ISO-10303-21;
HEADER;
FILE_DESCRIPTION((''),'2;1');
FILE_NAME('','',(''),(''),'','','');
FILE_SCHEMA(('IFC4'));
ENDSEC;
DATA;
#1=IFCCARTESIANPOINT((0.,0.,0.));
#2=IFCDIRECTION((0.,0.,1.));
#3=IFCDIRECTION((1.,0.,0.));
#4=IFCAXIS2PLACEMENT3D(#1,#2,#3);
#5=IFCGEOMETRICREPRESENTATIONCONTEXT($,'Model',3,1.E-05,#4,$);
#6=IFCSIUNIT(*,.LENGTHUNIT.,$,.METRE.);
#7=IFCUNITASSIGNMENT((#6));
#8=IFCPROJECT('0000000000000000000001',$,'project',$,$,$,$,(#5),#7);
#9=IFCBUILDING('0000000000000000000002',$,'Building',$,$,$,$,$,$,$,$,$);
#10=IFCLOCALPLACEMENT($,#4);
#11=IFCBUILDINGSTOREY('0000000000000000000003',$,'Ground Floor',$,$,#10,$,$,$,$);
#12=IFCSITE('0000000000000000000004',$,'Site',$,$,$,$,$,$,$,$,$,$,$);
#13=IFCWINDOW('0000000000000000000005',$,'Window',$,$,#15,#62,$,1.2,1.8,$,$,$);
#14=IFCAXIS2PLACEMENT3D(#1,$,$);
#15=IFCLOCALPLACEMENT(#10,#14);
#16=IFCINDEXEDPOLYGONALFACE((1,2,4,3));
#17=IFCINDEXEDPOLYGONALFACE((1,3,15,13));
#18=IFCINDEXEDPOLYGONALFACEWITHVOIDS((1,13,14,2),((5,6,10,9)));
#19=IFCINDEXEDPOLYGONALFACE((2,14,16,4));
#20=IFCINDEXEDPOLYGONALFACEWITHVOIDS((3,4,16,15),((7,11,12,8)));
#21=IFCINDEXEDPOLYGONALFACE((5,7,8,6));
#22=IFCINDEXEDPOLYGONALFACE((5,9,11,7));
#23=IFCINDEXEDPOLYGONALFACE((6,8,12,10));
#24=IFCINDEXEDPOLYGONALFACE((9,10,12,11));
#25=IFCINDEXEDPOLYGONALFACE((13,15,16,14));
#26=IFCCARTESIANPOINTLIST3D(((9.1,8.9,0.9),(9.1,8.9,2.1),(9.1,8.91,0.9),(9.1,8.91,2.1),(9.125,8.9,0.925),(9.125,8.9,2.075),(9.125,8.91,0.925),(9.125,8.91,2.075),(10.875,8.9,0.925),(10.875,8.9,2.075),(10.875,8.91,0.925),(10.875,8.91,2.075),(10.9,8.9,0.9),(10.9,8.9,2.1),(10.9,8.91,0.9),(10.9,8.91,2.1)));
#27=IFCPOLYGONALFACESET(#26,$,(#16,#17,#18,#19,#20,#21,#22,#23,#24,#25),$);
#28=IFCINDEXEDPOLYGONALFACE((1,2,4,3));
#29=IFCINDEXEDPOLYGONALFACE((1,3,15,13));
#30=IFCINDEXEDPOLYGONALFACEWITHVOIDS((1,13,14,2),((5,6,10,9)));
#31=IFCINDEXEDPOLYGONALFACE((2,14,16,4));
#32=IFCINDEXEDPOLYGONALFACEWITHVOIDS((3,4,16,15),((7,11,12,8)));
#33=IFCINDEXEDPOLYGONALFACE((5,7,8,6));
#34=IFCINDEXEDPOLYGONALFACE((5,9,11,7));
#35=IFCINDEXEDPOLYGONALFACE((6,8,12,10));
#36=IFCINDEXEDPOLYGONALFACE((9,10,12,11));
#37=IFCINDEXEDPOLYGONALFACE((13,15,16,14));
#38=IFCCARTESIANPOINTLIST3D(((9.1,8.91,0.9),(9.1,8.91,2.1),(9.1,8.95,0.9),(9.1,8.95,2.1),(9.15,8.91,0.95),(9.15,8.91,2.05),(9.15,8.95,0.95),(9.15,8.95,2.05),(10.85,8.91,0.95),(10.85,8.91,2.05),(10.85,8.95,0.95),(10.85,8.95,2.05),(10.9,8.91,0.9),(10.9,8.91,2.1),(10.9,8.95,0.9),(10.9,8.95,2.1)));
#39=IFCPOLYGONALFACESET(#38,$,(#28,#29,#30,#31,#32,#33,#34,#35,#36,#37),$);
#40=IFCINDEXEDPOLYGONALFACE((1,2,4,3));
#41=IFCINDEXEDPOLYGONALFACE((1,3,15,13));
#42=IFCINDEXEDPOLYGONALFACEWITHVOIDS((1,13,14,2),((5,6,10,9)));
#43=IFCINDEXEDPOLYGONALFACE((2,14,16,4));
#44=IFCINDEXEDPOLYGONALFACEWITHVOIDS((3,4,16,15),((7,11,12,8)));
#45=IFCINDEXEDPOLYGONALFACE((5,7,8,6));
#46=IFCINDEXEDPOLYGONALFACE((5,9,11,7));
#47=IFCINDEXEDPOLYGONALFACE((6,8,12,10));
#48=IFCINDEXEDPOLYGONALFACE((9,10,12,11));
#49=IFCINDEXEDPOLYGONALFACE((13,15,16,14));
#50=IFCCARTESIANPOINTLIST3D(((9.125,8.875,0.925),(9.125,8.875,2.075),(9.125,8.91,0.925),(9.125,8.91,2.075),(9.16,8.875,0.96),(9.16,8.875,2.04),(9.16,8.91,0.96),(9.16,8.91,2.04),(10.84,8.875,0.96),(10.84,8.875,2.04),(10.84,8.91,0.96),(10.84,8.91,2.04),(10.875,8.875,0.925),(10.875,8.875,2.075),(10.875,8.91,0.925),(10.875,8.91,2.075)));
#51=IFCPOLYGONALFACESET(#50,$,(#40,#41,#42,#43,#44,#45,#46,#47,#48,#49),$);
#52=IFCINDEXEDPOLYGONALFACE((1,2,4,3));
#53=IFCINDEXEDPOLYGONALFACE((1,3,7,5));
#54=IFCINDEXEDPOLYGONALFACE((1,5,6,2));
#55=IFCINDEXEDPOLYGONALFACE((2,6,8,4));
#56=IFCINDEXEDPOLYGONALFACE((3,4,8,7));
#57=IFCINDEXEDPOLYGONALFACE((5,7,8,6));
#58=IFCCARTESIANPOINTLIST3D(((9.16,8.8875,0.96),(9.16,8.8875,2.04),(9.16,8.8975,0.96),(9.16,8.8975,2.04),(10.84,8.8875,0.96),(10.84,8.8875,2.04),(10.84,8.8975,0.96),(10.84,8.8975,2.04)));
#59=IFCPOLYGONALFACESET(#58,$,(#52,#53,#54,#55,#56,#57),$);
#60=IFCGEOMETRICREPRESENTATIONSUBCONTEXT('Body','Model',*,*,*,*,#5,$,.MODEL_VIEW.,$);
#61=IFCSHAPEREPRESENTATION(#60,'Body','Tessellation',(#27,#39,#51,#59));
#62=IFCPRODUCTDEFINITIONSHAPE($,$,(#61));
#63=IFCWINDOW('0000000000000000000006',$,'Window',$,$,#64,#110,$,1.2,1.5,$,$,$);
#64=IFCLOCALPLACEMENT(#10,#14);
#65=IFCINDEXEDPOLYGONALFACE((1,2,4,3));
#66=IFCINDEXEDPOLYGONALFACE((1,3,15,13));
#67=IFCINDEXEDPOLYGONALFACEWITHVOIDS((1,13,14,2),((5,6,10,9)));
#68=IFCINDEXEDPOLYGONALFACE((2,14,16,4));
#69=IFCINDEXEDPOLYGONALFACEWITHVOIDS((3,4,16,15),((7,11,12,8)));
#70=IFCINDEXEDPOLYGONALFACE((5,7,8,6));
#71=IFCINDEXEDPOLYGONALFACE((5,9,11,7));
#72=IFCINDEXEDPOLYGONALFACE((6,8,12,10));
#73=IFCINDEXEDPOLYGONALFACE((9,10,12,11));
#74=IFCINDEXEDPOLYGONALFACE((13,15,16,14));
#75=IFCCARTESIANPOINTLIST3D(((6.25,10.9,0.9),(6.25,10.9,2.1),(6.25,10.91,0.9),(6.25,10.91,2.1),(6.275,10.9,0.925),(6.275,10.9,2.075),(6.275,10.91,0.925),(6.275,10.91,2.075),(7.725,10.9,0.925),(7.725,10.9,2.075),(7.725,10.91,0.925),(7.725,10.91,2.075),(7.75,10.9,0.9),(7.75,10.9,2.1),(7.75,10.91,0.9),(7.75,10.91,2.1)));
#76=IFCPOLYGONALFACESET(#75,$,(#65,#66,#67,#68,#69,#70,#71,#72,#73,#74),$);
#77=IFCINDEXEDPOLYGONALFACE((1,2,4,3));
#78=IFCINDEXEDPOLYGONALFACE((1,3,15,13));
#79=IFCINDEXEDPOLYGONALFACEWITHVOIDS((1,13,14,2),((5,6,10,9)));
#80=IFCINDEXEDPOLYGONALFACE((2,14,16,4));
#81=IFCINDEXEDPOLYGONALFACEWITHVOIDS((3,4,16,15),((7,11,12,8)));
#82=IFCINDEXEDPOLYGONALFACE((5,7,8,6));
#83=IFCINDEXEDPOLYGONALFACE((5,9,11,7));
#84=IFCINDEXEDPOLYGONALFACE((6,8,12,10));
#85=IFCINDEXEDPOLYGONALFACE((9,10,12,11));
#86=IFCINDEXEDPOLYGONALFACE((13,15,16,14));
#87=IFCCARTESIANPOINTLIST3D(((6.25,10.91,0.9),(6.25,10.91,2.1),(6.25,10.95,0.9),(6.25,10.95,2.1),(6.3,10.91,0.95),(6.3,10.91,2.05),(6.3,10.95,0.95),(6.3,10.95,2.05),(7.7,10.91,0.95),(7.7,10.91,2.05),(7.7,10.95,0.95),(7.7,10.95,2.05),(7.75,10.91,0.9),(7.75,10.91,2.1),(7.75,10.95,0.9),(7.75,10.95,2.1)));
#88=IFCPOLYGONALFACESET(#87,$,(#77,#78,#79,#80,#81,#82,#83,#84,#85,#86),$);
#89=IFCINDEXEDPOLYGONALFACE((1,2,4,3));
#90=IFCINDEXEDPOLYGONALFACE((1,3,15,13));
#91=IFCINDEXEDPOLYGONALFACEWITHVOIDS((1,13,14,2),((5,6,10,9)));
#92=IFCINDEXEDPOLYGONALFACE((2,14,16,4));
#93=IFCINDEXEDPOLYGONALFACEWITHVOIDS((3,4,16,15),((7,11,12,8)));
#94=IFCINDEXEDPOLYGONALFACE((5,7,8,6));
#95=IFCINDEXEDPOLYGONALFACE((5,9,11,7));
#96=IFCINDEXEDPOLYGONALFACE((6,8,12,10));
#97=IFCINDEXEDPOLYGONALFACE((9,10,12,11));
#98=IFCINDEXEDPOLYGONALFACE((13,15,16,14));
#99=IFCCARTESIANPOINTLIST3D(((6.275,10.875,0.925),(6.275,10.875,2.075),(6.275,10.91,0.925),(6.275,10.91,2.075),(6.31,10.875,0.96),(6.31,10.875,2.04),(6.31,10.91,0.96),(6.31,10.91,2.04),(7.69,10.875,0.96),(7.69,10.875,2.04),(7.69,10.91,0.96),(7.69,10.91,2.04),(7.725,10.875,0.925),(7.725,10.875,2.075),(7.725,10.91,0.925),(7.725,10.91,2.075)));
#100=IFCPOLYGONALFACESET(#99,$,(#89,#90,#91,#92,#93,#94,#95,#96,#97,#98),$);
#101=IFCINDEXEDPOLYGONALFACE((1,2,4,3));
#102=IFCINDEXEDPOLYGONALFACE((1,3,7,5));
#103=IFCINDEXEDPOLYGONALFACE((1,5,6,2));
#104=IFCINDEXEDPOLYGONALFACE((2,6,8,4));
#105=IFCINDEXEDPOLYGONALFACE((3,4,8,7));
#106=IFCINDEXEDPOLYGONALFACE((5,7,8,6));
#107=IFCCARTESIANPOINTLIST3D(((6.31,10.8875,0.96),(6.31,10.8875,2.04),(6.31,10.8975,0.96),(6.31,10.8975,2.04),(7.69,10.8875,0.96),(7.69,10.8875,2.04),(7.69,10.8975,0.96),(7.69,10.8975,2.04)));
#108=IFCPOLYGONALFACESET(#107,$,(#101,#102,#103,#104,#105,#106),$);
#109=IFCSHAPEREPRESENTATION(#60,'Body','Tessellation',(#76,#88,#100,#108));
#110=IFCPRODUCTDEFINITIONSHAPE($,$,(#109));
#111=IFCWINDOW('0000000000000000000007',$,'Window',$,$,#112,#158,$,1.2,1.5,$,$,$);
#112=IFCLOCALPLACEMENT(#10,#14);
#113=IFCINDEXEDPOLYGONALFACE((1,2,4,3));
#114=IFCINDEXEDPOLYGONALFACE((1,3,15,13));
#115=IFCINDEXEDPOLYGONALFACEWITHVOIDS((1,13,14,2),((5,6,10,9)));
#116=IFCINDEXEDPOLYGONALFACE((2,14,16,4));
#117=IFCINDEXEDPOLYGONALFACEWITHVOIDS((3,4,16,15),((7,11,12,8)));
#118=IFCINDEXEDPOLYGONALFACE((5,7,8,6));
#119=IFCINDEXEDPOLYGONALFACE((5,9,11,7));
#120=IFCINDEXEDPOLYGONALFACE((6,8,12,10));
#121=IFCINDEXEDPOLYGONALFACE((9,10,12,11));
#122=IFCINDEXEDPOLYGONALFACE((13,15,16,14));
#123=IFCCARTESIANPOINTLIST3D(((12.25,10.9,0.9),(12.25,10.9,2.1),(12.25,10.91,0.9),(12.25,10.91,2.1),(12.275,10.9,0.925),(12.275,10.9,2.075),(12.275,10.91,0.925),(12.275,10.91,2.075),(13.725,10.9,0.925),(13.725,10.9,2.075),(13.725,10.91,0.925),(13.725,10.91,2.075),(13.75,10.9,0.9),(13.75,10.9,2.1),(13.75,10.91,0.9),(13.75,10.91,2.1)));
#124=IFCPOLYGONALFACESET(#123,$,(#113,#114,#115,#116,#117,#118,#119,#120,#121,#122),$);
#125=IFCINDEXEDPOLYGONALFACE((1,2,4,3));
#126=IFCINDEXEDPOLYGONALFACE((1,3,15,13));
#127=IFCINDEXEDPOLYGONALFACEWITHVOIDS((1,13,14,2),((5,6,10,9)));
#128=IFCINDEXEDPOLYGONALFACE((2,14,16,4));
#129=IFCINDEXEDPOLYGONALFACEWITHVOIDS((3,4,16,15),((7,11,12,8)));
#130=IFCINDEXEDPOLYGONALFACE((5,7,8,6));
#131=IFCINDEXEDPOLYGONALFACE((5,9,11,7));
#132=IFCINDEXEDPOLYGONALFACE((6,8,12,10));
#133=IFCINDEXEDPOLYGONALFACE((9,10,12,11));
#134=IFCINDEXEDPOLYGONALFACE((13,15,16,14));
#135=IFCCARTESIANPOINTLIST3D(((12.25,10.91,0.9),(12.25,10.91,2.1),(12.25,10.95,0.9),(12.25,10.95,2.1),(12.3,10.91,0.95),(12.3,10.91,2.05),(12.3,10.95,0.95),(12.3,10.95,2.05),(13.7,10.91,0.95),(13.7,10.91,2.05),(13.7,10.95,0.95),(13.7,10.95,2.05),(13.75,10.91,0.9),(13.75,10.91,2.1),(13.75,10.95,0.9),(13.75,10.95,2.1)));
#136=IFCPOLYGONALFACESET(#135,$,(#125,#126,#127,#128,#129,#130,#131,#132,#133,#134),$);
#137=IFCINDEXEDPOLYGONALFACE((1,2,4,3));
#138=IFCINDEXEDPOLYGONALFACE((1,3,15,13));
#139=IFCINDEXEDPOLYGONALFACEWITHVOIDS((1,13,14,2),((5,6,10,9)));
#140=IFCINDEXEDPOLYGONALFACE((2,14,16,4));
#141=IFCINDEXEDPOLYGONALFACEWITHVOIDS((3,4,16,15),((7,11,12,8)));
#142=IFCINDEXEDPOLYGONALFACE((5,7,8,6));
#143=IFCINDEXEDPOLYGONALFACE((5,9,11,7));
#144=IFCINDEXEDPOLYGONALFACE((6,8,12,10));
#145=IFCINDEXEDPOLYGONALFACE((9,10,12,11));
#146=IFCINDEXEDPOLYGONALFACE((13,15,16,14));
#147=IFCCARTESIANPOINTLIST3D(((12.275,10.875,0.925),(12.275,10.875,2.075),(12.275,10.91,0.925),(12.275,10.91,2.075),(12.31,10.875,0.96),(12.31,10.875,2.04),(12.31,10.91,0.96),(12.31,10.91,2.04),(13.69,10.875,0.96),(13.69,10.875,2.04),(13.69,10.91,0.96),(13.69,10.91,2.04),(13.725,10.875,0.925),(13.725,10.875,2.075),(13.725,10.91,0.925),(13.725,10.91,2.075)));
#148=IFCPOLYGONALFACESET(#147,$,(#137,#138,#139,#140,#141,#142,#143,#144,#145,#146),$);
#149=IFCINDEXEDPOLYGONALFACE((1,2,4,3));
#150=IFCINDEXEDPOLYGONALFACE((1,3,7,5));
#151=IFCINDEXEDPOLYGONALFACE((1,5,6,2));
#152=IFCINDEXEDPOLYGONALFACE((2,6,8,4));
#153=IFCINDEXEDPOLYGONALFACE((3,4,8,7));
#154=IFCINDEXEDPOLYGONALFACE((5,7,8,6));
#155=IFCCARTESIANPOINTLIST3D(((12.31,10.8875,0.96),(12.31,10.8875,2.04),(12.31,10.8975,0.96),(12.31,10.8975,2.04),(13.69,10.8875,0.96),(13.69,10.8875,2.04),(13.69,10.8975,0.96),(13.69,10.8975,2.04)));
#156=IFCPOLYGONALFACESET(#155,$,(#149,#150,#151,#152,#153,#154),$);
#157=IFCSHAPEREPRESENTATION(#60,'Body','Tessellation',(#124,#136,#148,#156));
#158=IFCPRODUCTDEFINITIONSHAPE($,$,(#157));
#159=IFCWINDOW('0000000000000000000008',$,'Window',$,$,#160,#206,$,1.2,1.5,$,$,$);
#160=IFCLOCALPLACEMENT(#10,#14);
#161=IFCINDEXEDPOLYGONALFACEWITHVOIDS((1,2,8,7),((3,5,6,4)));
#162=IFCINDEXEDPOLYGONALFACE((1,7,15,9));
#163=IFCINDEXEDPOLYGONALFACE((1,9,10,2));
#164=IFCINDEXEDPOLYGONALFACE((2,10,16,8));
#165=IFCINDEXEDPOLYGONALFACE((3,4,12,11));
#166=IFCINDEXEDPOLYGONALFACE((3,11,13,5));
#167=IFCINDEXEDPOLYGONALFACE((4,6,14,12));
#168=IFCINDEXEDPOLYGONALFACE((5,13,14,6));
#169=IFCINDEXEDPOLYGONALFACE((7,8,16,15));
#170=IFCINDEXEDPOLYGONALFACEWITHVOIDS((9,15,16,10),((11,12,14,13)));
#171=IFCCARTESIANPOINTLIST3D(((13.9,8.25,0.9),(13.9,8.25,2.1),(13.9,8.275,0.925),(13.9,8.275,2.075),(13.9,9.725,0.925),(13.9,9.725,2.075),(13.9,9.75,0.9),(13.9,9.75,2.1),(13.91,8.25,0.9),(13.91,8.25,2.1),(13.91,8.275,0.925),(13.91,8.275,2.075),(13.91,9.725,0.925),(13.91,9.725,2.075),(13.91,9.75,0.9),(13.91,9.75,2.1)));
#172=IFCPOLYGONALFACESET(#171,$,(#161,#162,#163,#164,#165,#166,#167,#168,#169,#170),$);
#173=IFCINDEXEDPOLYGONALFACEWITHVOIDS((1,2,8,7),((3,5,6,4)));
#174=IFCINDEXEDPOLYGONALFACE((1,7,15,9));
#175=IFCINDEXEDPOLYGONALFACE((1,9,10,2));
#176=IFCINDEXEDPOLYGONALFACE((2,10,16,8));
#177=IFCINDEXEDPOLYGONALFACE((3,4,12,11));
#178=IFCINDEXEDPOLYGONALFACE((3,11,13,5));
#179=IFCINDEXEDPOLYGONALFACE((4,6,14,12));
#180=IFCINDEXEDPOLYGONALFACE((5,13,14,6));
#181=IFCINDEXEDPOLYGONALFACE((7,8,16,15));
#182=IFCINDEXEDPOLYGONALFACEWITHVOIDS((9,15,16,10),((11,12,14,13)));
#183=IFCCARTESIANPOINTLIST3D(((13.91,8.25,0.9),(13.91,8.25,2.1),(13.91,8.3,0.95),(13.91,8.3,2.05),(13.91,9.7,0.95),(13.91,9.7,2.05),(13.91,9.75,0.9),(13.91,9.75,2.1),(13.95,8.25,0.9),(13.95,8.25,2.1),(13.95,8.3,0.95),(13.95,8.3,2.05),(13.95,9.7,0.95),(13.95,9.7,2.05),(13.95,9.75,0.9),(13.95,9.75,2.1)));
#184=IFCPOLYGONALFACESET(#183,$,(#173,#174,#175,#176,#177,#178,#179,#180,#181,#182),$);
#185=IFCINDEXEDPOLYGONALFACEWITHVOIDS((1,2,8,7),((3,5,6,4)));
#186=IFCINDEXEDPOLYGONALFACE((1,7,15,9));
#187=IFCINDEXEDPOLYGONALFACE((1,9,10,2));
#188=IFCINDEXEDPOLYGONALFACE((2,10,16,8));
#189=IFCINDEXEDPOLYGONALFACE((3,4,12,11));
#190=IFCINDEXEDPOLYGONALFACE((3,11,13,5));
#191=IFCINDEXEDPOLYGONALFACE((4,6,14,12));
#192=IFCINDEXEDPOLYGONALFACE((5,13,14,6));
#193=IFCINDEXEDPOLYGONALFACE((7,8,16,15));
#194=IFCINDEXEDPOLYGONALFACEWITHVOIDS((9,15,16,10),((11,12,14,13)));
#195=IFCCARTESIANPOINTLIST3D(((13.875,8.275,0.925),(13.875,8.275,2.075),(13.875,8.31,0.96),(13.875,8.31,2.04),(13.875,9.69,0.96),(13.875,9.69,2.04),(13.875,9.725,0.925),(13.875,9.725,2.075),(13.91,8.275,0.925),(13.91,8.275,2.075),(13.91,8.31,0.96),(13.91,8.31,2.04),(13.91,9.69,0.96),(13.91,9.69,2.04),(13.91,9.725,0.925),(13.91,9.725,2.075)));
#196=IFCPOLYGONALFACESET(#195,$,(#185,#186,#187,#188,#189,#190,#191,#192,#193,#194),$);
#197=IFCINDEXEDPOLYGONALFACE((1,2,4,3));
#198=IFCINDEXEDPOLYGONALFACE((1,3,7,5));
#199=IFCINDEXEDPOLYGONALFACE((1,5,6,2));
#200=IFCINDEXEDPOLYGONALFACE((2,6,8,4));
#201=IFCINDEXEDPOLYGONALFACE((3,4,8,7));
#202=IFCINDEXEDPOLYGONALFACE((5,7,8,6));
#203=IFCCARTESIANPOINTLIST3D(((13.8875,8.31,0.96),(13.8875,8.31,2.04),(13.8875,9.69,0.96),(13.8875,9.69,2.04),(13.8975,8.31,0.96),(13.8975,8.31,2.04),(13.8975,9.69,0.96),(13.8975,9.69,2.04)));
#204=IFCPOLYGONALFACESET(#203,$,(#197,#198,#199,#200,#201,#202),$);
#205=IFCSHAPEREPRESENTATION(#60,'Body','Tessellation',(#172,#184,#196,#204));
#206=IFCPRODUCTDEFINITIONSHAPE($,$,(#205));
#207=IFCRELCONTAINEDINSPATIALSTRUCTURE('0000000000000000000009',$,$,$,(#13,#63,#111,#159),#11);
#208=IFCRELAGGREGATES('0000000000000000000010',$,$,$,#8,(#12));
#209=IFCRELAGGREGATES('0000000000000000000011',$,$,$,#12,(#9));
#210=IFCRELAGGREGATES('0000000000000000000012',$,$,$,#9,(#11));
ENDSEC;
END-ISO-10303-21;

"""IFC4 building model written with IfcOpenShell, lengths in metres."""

from ifc_helpers import new_model, si_unit, frame, origin_with_axes, place, context, subcontext, project, spatial, line, indexed_curve, outline, extrude, element, save


model = new_model("IFC4")

# Units and contexts
model_context = context("Model", 3, precision=1e-05, world=origin_with_axes())
body_context = subcontext(model_context, "Body", "Model", "MODEL_VIEW")
ifc_project = project(units=[si_unit("LENGTHUNIT", "METRE")], contexts=[model_context])

# Site, building, storey
site = spatial("IfcSite", under=ifc_project, Name="Site")
building = spatial("IfcBuilding", under=site, Name="Building")
storey_placement = place(None, origin_with_axes())
storey = spatial("IfcBuildingStorey", under=building, at=storey_placement, Name="Ground Floor")

# Windows
window_1_placement = place(storey_placement, frame((10.9, 9.0, 0.9), z_axis=(0.0, 0.0, 1.0), x_axis=(-1.0, 0.0, 0.0)))
element("IfcWindow", 1, at=window_1_placement, inside=storey, Name="Window", OverallHeight=1.2, OverallWidth=1.8, context=body_context, shape_type="SweptSolid", body=[
    extrude(outline(indexed_curve([(0.0, 0.0), (1.8, 0.0), (1.8, 1.2), (0.0, 1.2)], segments=[line(1, 2, 3, 4, 1)]), holes=[indexed_curve([(0.025, 0.025), (1.775, 0.025), (1.775, 1.175), (0.025, 1.175)], segments=[line(1, 2, 3, 4, 1)])]), frame((0.0, 0.09, 0.0), z_axis=(0.0, -1.0, 0.0), x_axis=(1.0, 0.0, 0.0)), (0.0, 0.0, -1.0), 0.01),
    extrude(outline(indexed_curve([(0.0, 0.0), (1.8, 0.0), (1.8, 1.2), (0.0, 1.2)], segments=[line(1, 2, 3, 4, 1)]), holes=[indexed_curve([(0.05, 0.05), (1.75, 0.05), (1.75, 1.15), (0.05, 1.15)], segments=[line(1, 2, 3, 4, 1)])]), frame((0.0, 0.05, 0.0), z_axis=(0.0, -1.0, 0.0), x_axis=(1.0, 0.0, 0.0)), (0.0, 0.0, -1.0), 0.04),
    extrude(outline(indexed_curve([(0.0, 0.0), (1.75, 0.0), (1.75, 1.15), (0.0, 1.15)], segments=[line(1, 2, 3, 4, 1)]), holes=[indexed_curve([(0.035, 0.035), (1.715, 0.035), (1.715, 1.115), (0.035, 1.115)], segments=[line(1, 2, 3, 4, 1)])]), frame((0.025, 0.09, 0.025), z_axis=(0.0, -1.0, 0.0), x_axis=(1.0, 0.0, 0.0)), (0.0, 0.0, -1.0), 0.035),
    extrude(outline(indexed_curve([(0.035, 0.035), (1.715, 0.035), (1.715, 1.115), (0.035, 1.115)], segments=[line(1, 2, 3, 4, 1)])), frame((0.025, 0.1025, 0.025), z_axis=(0.0, -1.0, 0.0), x_axis=(1.0, 0.0, 0.0)), (0.0, 0.0, -1.0), 0.01),
])
for number, where, z_axis, x_axis, name in (
    (2, (7.75, 11.0, 0.9), (0.0, 0.0, 1.0), (-1.0, 0.0, 0.0), "Window"),
    (3, (13.75, 11.0, 0.9), (0.0, 0.0, 1.0), (-1.0, 0.0, 0.0), "Window"),
    (4, (14.0, 8.25, 0.9), (0.0, 0.0, 1.0), (0.0, 1.0, 0.0), "Window"),
):
    element("IfcWindow", number, at=place(storey_placement, frame(where, z_axis=z_axis, x_axis=x_axis)), inside=storey, Name=name, OverallHeight=1.2, OverallWidth=1.5, context=body_context, shape_type="SweptSolid", body=[
        extrude(outline(indexed_curve([(0.0, 0.0), (1.5, 0.0), (1.5, 1.2), (0.0, 1.2)], segments=[line(1, 2, 3, 4, 1)]), holes=[indexed_curve([(0.025, 0.025), (1.475, 0.025), (1.475, 1.175), (0.025, 1.175)], segments=[line(1, 2, 3, 4, 1)])]), frame((0.0, 0.09, 0.0), z_axis=(0.0, -1.0, 0.0), x_axis=(1.0, 0.0, 0.0)), (0.0, 0.0, -1.0), 0.01),
        extrude(outline(indexed_curve([(0.0, 0.0), (1.5, 0.0), (1.5, 1.2), (0.0, 1.2)], segments=[line(1, 2, 3, 4, 1)]), holes=[indexed_curve([(0.05, 0.05), (1.45, 0.05), (1.45, 1.15), (0.05, 1.15)], segments=[line(1, 2, 3, 4, 1)])]), frame((0.0, 0.05, 0.0), z_axis=(0.0, -1.0, 0.0), x_axis=(1.0, 0.0, 0.0)), (0.0, 0.0, -1.0), 0.04),
        extrude(outline(indexed_curve([(0.0, 0.0), (1.45, 0.0), (1.45, 1.15), (0.0, 1.15)], segments=[line(1, 2, 3, 4, 1)]), holes=[indexed_curve([(0.035, 0.035), (1.415, 0.035), (1.415, 1.115), (0.035, 1.115)], segments=[line(1, 2, 3, 4, 1)])]), frame((0.025, 0.09, 0.025), z_axis=(0.0, -1.0, 0.0), x_axis=(1.0, 0.0, 0.0)), (0.0, 0.0, -1.0), 0.035),
        extrude(outline(indexed_curve([(0.035, 0.035), (1.415, 0.035), (1.415, 1.115), (0.035, 1.115)], segments=[line(1, 2, 3, 4, 1)])), frame((0.025, 0.1025, 0.025), z_axis=(0.0, -1.0, 0.0), x_axis=(1.0, 0.0, 0.0)), (0.0, 0.0, -1.0), 0.01),
    ])

save(model, "model.ifc")
